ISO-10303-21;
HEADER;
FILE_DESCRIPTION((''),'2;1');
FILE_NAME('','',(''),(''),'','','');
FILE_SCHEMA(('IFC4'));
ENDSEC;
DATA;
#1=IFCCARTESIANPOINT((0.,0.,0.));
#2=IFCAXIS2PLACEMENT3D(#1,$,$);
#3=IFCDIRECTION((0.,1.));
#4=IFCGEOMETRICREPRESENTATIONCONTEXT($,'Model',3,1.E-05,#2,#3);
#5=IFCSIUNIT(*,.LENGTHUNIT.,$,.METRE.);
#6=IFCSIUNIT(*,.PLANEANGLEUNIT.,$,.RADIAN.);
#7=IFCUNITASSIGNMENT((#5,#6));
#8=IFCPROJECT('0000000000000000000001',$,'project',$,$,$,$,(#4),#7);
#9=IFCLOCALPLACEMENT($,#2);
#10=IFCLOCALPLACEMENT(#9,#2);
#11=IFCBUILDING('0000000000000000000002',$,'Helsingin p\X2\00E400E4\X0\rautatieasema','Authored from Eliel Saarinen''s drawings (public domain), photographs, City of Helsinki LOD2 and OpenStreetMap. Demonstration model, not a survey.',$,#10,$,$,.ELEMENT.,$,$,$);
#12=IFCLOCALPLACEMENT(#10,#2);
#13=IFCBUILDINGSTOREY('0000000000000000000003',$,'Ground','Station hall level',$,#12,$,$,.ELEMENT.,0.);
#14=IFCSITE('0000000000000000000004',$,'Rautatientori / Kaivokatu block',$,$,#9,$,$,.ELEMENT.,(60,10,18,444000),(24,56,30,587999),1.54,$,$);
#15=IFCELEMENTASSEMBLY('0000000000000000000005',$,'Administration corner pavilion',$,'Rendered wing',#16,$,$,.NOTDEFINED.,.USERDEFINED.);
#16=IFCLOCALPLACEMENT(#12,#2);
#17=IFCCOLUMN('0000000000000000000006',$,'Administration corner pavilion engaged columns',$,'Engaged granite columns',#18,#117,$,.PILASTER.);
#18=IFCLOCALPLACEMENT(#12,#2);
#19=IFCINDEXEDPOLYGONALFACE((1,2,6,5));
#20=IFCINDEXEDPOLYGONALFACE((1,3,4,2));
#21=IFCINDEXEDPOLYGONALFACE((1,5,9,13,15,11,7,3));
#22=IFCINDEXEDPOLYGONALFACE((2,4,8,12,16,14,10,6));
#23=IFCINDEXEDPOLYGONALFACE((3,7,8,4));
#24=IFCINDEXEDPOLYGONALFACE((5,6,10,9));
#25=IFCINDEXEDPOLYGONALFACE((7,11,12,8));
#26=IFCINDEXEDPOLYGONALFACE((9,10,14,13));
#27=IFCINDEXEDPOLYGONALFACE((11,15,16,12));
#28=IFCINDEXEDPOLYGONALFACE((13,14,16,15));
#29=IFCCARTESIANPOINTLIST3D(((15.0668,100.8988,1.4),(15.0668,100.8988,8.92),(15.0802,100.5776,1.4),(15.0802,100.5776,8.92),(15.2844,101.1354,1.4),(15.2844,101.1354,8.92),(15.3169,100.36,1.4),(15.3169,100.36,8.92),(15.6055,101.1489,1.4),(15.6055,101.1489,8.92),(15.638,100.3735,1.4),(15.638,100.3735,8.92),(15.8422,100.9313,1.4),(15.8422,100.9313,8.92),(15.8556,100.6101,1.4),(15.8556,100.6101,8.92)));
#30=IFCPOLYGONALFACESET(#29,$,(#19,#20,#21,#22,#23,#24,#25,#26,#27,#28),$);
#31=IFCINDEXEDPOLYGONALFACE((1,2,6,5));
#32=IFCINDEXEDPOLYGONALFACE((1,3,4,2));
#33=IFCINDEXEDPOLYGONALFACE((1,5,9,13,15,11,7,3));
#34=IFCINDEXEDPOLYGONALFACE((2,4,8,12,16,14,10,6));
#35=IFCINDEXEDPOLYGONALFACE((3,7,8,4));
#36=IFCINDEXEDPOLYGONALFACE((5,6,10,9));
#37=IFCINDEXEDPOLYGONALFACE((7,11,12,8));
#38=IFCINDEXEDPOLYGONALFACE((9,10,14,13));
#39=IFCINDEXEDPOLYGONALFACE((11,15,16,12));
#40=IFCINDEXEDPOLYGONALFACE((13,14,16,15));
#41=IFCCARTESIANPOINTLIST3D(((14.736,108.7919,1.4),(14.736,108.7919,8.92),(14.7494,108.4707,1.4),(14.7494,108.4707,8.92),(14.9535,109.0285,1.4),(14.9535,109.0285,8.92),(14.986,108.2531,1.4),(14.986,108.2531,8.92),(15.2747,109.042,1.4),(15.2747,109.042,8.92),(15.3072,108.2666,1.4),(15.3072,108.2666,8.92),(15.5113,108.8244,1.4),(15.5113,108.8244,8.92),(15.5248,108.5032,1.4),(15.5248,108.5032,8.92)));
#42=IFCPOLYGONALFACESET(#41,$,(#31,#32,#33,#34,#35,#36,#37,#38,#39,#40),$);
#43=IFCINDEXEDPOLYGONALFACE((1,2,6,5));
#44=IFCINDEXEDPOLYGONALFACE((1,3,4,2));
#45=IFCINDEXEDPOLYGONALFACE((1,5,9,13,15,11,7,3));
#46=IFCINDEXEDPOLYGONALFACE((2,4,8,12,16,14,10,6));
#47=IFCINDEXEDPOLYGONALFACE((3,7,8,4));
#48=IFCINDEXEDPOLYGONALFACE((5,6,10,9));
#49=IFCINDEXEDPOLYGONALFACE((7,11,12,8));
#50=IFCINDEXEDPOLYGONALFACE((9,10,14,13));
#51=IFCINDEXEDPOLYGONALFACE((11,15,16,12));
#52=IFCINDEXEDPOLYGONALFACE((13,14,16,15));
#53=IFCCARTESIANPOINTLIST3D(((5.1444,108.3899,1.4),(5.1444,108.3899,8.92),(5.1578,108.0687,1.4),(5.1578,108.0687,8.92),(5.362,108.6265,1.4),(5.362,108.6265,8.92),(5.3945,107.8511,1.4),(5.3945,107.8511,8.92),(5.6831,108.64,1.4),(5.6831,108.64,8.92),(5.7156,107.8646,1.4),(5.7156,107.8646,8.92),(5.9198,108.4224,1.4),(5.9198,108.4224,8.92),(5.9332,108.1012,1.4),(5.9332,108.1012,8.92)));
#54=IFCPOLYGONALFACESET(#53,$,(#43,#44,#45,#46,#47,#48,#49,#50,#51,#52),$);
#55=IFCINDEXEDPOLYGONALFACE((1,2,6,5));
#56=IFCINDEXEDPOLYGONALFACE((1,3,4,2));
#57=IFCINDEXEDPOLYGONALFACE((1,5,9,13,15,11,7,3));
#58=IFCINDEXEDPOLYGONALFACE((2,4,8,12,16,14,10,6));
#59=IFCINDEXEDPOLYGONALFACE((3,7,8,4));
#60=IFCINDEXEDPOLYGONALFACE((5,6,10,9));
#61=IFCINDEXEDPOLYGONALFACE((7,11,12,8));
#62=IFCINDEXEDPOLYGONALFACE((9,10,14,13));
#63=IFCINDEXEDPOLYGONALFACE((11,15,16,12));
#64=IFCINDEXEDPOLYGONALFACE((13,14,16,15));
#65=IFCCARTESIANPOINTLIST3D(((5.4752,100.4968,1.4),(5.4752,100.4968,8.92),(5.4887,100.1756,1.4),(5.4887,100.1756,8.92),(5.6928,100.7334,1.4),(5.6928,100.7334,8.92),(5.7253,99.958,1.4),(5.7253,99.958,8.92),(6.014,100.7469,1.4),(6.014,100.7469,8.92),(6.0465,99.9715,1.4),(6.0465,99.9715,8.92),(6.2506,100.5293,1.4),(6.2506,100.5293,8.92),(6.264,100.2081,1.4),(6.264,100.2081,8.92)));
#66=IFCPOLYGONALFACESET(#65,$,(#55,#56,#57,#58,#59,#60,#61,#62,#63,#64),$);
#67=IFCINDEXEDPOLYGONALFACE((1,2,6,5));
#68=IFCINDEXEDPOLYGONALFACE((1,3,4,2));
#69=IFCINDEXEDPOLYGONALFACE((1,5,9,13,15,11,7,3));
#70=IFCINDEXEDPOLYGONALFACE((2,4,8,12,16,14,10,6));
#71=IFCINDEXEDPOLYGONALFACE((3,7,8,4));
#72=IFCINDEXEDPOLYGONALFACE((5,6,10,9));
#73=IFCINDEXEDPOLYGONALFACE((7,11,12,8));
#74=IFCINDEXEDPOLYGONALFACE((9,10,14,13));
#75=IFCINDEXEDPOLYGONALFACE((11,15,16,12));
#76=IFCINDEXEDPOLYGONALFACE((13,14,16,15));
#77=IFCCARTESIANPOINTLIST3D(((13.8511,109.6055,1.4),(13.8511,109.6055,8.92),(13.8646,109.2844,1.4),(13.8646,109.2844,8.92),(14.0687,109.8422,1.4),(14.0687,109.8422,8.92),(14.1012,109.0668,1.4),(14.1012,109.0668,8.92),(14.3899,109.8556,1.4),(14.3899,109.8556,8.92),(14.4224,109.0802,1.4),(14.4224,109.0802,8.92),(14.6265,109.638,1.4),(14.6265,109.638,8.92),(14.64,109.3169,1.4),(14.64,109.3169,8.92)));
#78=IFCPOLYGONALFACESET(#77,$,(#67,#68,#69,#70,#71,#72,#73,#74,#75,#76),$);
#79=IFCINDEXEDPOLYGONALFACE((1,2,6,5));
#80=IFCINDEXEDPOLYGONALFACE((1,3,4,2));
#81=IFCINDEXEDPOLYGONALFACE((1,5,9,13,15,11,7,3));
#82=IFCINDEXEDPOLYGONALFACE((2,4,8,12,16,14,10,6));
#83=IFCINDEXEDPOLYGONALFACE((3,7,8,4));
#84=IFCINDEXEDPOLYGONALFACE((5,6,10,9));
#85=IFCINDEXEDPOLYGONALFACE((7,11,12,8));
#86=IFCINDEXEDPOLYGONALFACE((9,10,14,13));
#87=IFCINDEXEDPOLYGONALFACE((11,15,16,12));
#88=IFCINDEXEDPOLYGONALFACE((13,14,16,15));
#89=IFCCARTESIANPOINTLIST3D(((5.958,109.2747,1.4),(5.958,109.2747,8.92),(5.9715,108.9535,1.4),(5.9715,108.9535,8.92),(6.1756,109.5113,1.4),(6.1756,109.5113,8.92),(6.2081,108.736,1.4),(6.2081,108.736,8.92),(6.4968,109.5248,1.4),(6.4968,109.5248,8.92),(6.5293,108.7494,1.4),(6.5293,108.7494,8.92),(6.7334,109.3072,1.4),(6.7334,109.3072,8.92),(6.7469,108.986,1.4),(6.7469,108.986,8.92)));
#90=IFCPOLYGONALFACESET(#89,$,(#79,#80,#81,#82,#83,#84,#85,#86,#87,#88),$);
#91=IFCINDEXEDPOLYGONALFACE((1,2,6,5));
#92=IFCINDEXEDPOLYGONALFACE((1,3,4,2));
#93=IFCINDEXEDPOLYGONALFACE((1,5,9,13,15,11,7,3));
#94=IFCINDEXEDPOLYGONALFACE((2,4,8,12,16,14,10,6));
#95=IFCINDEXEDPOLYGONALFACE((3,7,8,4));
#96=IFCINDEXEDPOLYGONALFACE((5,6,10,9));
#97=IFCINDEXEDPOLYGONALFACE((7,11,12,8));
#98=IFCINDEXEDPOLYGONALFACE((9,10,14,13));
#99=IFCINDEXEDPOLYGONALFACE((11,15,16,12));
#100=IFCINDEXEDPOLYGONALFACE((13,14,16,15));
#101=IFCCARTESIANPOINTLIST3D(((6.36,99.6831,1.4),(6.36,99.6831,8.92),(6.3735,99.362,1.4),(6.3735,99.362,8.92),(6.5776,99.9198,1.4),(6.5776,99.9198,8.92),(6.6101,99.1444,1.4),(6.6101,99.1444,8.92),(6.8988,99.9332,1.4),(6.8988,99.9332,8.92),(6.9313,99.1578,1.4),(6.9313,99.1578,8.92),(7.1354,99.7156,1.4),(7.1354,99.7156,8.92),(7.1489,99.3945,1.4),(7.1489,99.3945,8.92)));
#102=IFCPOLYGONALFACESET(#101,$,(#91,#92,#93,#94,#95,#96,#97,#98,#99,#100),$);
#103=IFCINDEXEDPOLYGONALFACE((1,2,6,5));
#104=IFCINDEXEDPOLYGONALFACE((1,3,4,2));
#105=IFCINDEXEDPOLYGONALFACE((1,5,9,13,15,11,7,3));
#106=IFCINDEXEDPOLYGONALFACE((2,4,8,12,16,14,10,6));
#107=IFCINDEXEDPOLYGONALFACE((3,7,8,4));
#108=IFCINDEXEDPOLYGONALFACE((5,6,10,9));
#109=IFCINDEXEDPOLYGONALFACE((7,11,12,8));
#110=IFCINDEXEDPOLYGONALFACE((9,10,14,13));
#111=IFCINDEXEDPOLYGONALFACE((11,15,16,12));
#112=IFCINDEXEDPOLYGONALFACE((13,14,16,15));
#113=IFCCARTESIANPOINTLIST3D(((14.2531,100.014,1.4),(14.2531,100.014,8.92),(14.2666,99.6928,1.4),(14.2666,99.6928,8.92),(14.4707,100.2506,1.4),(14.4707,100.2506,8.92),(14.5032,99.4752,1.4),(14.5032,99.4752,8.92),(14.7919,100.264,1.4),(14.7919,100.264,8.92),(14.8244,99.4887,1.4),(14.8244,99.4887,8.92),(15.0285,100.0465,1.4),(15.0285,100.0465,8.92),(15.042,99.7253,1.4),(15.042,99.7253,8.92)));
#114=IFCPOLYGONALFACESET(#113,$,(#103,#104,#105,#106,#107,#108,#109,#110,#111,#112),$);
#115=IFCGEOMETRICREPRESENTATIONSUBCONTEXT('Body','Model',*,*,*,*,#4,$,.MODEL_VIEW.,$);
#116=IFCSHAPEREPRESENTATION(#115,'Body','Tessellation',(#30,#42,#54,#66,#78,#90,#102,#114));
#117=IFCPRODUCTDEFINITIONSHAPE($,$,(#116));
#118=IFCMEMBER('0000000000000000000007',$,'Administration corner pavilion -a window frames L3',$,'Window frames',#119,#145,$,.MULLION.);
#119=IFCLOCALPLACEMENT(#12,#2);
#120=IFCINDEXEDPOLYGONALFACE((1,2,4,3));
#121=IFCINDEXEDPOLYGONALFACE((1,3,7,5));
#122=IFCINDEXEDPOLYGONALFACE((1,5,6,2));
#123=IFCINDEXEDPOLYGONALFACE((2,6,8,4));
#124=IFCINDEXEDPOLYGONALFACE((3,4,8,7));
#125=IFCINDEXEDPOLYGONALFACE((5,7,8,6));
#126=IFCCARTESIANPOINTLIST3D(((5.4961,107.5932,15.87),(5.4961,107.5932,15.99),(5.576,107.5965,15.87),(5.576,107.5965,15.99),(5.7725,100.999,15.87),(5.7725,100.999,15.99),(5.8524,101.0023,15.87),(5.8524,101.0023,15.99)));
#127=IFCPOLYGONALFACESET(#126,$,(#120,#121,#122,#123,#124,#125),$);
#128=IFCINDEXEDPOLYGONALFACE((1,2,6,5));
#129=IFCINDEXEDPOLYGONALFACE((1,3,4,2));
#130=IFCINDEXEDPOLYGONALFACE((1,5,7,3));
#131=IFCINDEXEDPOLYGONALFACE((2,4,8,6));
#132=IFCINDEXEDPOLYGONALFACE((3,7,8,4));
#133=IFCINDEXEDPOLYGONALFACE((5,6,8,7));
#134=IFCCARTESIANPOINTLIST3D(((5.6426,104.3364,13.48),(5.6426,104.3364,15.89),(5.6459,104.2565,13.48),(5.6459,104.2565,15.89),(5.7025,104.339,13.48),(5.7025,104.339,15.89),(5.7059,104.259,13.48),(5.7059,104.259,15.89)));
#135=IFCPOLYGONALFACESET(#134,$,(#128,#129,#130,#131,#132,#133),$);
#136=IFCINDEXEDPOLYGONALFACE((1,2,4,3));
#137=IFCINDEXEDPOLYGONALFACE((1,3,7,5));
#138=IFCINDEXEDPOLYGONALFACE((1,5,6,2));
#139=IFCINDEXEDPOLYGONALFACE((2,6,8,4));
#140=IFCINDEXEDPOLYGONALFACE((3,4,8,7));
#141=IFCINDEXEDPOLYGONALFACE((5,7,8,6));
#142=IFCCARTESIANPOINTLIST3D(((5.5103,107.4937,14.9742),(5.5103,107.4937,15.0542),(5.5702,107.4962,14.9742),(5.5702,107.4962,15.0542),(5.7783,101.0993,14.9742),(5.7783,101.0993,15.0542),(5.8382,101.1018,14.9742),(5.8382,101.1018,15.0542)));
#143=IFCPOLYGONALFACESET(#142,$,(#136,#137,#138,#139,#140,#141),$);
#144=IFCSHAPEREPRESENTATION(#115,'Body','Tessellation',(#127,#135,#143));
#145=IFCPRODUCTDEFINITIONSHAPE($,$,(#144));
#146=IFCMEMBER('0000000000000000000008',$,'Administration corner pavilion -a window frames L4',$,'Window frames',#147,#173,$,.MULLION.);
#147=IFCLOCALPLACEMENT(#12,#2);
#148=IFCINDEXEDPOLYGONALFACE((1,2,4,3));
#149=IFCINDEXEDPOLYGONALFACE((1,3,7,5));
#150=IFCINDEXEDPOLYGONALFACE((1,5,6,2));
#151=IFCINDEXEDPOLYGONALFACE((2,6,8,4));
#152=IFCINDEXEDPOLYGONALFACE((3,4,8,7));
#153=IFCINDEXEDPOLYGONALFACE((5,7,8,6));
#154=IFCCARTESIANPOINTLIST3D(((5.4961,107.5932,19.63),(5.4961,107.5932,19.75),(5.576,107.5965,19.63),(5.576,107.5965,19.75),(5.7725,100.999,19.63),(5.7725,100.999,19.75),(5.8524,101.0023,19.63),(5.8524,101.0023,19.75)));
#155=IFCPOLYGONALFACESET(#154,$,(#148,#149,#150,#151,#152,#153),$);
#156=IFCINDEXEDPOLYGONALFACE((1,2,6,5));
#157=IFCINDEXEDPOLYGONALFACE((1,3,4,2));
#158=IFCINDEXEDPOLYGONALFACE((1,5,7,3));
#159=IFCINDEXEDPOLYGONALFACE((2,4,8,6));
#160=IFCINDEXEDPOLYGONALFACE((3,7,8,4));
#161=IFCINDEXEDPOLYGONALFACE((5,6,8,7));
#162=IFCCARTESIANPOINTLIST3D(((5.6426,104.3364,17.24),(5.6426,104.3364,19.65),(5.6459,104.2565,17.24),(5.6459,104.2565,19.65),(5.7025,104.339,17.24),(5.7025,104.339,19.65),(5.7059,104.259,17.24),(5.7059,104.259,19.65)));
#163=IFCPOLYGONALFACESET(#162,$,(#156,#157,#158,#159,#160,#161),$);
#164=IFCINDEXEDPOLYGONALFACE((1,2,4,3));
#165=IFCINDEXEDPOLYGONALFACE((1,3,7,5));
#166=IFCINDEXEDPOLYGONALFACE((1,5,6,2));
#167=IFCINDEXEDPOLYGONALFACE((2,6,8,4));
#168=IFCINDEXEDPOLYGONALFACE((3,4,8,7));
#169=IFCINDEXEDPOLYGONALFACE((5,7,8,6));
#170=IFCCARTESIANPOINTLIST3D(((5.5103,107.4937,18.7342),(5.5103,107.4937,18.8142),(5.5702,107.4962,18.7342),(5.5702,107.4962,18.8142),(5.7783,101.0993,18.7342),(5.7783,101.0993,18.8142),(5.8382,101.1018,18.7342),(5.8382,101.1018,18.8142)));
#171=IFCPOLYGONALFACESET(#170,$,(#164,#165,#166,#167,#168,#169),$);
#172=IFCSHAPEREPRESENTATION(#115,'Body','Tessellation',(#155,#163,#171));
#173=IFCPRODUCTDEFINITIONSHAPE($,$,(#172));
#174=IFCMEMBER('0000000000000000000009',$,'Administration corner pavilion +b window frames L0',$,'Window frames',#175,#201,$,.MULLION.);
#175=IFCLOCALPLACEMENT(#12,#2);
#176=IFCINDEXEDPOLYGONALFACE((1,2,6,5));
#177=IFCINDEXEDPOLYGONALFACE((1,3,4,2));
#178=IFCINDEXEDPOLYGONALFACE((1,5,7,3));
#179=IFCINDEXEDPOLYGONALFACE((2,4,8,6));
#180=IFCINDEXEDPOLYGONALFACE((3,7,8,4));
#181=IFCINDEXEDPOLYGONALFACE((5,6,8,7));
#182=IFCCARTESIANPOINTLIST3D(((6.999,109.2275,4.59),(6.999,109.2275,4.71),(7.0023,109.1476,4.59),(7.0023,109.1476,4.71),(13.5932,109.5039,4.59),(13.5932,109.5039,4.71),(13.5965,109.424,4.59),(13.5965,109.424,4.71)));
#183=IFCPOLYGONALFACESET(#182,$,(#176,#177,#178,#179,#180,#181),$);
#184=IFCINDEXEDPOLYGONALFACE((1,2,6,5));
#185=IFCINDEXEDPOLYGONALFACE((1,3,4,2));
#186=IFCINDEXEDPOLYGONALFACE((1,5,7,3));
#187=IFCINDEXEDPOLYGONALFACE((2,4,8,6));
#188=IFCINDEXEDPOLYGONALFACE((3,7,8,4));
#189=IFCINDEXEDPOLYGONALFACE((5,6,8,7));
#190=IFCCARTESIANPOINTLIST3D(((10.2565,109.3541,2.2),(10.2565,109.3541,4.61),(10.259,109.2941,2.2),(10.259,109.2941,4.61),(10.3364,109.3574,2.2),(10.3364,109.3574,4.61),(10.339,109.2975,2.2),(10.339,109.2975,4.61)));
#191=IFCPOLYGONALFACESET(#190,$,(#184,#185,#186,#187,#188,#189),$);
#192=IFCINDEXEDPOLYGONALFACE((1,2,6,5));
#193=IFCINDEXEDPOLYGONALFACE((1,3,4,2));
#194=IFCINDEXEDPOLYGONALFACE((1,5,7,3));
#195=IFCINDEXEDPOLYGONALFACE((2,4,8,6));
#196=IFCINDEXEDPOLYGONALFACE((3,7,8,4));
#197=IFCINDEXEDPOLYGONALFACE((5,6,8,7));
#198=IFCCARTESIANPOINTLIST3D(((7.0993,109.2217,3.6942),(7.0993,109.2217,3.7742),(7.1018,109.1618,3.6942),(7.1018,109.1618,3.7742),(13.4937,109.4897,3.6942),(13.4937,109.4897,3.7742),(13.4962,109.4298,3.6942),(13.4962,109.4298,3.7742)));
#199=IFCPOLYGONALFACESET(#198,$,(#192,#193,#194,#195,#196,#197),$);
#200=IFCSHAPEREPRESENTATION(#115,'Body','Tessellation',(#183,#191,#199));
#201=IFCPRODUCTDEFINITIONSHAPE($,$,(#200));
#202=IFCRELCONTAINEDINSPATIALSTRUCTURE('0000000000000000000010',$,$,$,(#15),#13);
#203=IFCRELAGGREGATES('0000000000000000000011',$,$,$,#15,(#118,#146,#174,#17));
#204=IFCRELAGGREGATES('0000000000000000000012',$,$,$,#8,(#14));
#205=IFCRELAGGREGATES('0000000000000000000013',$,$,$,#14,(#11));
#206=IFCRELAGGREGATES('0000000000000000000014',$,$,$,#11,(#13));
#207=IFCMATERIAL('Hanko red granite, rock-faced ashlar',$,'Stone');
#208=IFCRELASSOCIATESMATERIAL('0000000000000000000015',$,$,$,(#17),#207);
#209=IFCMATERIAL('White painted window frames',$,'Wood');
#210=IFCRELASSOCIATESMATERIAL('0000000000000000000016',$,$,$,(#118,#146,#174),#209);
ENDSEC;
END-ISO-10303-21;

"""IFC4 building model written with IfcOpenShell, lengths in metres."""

from ifc_helpers import new_model, si_unit, direction, frame, frame_2d, origin, place, context, subcontext, project, spatial, polyline, rectangle, outline, extrude, material, element, aggregate, save


model = new_model("IFC4")

# Units and contexts
model_context = context("Model", 3, precision=1e-05, world=origin(), true_north=direction((0.0, 1.0)))
body_context = subcontext(model_context, "Body", "Model", "MODEL_VIEW")
ifc_project = project(units=[si_unit("LENGTHUNIT", "METRE"), si_unit("PLANEANGLEUNIT", "RADIAN")], contexts=[model_context])

# Site, building, storey
site_placement = place(None, origin())
site = spatial("IfcSite", under=ifc_project, at=site_placement, Name="Rautatientori / Kaivokatu block", CompositionType="ELEMENT", RefLatitude=(60, 10, 18, 444000), RefLongitude=(24, 56, 30, 587999), RefElevation=1.54)
building_placement = place(site_placement, origin())
building = spatial("IfcBuilding", under=site, at=building_placement, Name="Helsingin päärautatieasema", Description="Authored from Eliel Saarinen's drawings (public domain), photographs, City of Helsinki LOD2 and OpenStreetMap. Demonstration model, not a survey.", CompositionType="ELEMENT")
storey_placement = place(building_placement, origin())
storey = spatial("IfcBuildingStorey", under=building, at=storey_placement, Name="Ground", Description="Station hall level", CompositionType="ELEMENT", Elevation=0.0)

# Element assembly, column, members
assembly_placement = place(building_placement, origin())
assembly = element("IfcElementAssembly", 1, at=assembly_placement, inside=storey, Name="Administration corner pavilion", ObjectType="Rendered wing", AssemblyPlace="NOTDEFINED", PredefinedType="USERDEFINED")
ifc_material_1 = material(Name="Hanko red granite, rock-faced ashlar", Category="Stone")
column_placement = place(building_placement, origin())
column = element("IfcColumn", 2, at=column_placement, material=ifc_material_1, Name="Administration corner pavilion engaged columns", ObjectType="Engaged granite columns", PredefinedType="PILASTER", context=body_context, shape_type="SweptSolid", body=[
    extrude(outline(polyline([(15.2844, 101.1354), (15.0668, 100.8988), (15.0802, 100.5776), (15.3169, 100.36), (15.638, 100.3735), (15.8556, 100.6101), (15.8422, 100.9313), (15.6055, 101.1489), (15.2844, 101.1354)])), frame((0.0, 0.0, 1.4)), (0.0, 0.0, 1.0), 7.52),
    extrude(outline(polyline([(14.9535, 109.0285), (14.736, 108.7919), (14.7494, 108.4707), (14.986, 108.2531), (15.3072, 108.2666), (15.5248, 108.5032), (15.5113, 108.8244), (15.2747, 109.042), (14.9535, 109.0285)])), frame((0.0, 0.0, 1.4)), (0.0, 0.0, 1.0), 7.52),
    extrude(outline(polyline([(5.7156, 107.8646), (5.9332, 108.1012), (5.9198, 108.4224), (5.6831, 108.64), (5.362, 108.6265), (5.1444, 108.3899), (5.1578, 108.0687), (5.3945, 107.8511), (5.7156, 107.8646)])), frame((0.0, 0.0, 1.4)), (0.0, 0.0, 1.0), 7.52),
    extrude(outline(polyline([(6.0465, 99.9715), (6.264, 100.2081), (6.2506, 100.5293), (6.014, 100.7469), (5.6928, 100.7334), (5.4752, 100.4968), (5.4887, 100.1756), (5.7253, 99.958), (6.0465, 99.9715)])), frame((0.0, 0.0, 1.4)), (0.0, 0.0, 1.0), 7.52),
    extrude(outline(polyline([(13.8646, 109.2844), (14.1012, 109.0668), (14.4224, 109.0802), (14.64, 109.3169), (14.6265, 109.638), (14.3899, 109.8556), (14.0687, 109.8422), (13.8511, 109.6055), (13.8646, 109.2844)])), frame((0.0, 0.0, 1.4)), (0.0, 0.0, 1.0), 7.52),
    extrude(outline(polyline([(5.9715, 108.9535), (6.2081, 108.736), (6.5293, 108.7494), (6.7469, 108.986), (6.7334, 109.3072), (6.4968, 109.5248), (6.1756, 109.5113), (5.958, 109.2747), (5.9715, 108.9535)])), frame((0.0, 0.0, 1.4)), (0.0, 0.0, 1.0), 7.52),
    extrude(outline(polyline([(7.1354, 99.7156), (6.8988, 99.9332), (6.5776, 99.9198), (6.36, 99.6831), (6.3735, 99.362), (6.6101, 99.1444), (6.9313, 99.1578), (7.1489, 99.3945), (7.1354, 99.7156)])), frame((0.0, 0.0, 1.4)), (0.0, 0.0, 1.0), 7.52),
    extrude(outline(polyline([(15.0285, 100.0465), (14.7919, 100.264), (14.4707, 100.2506), (14.2531, 100.014), (14.2666, 99.6928), (14.5032, 99.4752), (14.8244, 99.4887), (15.042, 99.7253), (15.0285, 100.0465)])), frame((0.0, 0.0, 1.4)), (0.0, 0.0, 1.0), 7.52),
])
ifc_material_2 = material(Name="White painted window frames", Category="Wood")
member_1_placement = place(building_placement, origin())
member_1 = element("IfcMember", 3, at=member_1_placement, material=ifc_material_2, Name="Administration corner pavilion -a window frames L3", ObjectType="Window frames", PredefinedType="MULLION", context=body_context, shape_type="SweptSolid", body=[
    extrude(rectangle(XDim=6.6, YDim=0.08, at=frame_2d((0.0, 0.0), x_axis=(0.041876, -0.999123))), frame((5.6742, 104.2977, 15.87)), (0.0, 0.0, 1.0), 0.12),
    extrude(rectangle(XDim=0.08, YDim=0.06, at=frame_2d((0.0, 0.0), x_axis=(0.041876, -0.999123))), frame((5.6742, 104.2977, 13.48)), (0.0, 0.0, 1.0), 2.41),
    extrude(rectangle(XDim=6.4, YDim=0.06, at=frame_2d((0.0, 0.0), x_axis=(0.041876, -0.999123))), frame((5.6742, 104.2977, 14.9742)), (0.0, 0.0, 1.0), 0.08),
])
member_2_placement = place(building_placement, origin())
member_2 = element("IfcMember", 4, at=member_2_placement, material=ifc_material_2, Name="Administration corner pavilion -a window frames L4", ObjectType="Window frames", PredefinedType="MULLION", context=body_context, shape_type="SweptSolid", body=[
    extrude(rectangle(XDim=6.6, YDim=0.08, at=frame_2d((0.0, 0.0), x_axis=(0.041876, -0.999123))), frame((5.6742, 104.2977, 19.63)), (0.0, 0.0, 1.0), 0.12),
    extrude(rectangle(XDim=0.08, YDim=0.06, at=frame_2d((0.0, 0.0), x_axis=(0.041876, -0.999123))), frame((5.6742, 104.2977, 17.24)), (0.0, 0.0, 1.0), 2.41),
    extrude(rectangle(XDim=6.4, YDim=0.06, at=frame_2d((0.0, 0.0), x_axis=(0.041876, -0.999123))), frame((5.6742, 104.2977, 18.7342)), (0.0, 0.0, 1.0), 0.08),
])
member_3_placement = place(building_placement, origin())
member_3 = element("IfcMember", 5, at=member_3_placement, material=ifc_material_2, Name="Administration corner pavilion +b window frames L0", ObjectType="Window frames", PredefinedType="MULLION", context=body_context, shape_type="SweptSolid", body=[
    extrude(rectangle(XDim=6.6, YDim=0.08, at=frame_2d((0.0, 0.0), x_axis=(-0.999123, -0.041876))), frame((10.2977, 109.3258, 4.59)), (0.0, 0.0, 1.0), 0.12),
    extrude(rectangle(XDim=0.08, YDim=0.06, at=frame_2d((0.0, 0.0), x_axis=(-0.999123, -0.041876))), frame((10.2977, 109.3258, 2.2)), (0.0, 0.0, 1.0), 2.41),
    extrude(rectangle(XDim=6.4, YDim=0.06, at=frame_2d((0.0, 0.0), x_axis=(-0.999123, -0.041876))), frame((10.2977, 109.3258, 3.6942)), (0.0, 0.0, 1.0), 0.08),
])
aggregate(assembly, [member_1, member_2, member_3, column])

save(model, "model.ifc")
